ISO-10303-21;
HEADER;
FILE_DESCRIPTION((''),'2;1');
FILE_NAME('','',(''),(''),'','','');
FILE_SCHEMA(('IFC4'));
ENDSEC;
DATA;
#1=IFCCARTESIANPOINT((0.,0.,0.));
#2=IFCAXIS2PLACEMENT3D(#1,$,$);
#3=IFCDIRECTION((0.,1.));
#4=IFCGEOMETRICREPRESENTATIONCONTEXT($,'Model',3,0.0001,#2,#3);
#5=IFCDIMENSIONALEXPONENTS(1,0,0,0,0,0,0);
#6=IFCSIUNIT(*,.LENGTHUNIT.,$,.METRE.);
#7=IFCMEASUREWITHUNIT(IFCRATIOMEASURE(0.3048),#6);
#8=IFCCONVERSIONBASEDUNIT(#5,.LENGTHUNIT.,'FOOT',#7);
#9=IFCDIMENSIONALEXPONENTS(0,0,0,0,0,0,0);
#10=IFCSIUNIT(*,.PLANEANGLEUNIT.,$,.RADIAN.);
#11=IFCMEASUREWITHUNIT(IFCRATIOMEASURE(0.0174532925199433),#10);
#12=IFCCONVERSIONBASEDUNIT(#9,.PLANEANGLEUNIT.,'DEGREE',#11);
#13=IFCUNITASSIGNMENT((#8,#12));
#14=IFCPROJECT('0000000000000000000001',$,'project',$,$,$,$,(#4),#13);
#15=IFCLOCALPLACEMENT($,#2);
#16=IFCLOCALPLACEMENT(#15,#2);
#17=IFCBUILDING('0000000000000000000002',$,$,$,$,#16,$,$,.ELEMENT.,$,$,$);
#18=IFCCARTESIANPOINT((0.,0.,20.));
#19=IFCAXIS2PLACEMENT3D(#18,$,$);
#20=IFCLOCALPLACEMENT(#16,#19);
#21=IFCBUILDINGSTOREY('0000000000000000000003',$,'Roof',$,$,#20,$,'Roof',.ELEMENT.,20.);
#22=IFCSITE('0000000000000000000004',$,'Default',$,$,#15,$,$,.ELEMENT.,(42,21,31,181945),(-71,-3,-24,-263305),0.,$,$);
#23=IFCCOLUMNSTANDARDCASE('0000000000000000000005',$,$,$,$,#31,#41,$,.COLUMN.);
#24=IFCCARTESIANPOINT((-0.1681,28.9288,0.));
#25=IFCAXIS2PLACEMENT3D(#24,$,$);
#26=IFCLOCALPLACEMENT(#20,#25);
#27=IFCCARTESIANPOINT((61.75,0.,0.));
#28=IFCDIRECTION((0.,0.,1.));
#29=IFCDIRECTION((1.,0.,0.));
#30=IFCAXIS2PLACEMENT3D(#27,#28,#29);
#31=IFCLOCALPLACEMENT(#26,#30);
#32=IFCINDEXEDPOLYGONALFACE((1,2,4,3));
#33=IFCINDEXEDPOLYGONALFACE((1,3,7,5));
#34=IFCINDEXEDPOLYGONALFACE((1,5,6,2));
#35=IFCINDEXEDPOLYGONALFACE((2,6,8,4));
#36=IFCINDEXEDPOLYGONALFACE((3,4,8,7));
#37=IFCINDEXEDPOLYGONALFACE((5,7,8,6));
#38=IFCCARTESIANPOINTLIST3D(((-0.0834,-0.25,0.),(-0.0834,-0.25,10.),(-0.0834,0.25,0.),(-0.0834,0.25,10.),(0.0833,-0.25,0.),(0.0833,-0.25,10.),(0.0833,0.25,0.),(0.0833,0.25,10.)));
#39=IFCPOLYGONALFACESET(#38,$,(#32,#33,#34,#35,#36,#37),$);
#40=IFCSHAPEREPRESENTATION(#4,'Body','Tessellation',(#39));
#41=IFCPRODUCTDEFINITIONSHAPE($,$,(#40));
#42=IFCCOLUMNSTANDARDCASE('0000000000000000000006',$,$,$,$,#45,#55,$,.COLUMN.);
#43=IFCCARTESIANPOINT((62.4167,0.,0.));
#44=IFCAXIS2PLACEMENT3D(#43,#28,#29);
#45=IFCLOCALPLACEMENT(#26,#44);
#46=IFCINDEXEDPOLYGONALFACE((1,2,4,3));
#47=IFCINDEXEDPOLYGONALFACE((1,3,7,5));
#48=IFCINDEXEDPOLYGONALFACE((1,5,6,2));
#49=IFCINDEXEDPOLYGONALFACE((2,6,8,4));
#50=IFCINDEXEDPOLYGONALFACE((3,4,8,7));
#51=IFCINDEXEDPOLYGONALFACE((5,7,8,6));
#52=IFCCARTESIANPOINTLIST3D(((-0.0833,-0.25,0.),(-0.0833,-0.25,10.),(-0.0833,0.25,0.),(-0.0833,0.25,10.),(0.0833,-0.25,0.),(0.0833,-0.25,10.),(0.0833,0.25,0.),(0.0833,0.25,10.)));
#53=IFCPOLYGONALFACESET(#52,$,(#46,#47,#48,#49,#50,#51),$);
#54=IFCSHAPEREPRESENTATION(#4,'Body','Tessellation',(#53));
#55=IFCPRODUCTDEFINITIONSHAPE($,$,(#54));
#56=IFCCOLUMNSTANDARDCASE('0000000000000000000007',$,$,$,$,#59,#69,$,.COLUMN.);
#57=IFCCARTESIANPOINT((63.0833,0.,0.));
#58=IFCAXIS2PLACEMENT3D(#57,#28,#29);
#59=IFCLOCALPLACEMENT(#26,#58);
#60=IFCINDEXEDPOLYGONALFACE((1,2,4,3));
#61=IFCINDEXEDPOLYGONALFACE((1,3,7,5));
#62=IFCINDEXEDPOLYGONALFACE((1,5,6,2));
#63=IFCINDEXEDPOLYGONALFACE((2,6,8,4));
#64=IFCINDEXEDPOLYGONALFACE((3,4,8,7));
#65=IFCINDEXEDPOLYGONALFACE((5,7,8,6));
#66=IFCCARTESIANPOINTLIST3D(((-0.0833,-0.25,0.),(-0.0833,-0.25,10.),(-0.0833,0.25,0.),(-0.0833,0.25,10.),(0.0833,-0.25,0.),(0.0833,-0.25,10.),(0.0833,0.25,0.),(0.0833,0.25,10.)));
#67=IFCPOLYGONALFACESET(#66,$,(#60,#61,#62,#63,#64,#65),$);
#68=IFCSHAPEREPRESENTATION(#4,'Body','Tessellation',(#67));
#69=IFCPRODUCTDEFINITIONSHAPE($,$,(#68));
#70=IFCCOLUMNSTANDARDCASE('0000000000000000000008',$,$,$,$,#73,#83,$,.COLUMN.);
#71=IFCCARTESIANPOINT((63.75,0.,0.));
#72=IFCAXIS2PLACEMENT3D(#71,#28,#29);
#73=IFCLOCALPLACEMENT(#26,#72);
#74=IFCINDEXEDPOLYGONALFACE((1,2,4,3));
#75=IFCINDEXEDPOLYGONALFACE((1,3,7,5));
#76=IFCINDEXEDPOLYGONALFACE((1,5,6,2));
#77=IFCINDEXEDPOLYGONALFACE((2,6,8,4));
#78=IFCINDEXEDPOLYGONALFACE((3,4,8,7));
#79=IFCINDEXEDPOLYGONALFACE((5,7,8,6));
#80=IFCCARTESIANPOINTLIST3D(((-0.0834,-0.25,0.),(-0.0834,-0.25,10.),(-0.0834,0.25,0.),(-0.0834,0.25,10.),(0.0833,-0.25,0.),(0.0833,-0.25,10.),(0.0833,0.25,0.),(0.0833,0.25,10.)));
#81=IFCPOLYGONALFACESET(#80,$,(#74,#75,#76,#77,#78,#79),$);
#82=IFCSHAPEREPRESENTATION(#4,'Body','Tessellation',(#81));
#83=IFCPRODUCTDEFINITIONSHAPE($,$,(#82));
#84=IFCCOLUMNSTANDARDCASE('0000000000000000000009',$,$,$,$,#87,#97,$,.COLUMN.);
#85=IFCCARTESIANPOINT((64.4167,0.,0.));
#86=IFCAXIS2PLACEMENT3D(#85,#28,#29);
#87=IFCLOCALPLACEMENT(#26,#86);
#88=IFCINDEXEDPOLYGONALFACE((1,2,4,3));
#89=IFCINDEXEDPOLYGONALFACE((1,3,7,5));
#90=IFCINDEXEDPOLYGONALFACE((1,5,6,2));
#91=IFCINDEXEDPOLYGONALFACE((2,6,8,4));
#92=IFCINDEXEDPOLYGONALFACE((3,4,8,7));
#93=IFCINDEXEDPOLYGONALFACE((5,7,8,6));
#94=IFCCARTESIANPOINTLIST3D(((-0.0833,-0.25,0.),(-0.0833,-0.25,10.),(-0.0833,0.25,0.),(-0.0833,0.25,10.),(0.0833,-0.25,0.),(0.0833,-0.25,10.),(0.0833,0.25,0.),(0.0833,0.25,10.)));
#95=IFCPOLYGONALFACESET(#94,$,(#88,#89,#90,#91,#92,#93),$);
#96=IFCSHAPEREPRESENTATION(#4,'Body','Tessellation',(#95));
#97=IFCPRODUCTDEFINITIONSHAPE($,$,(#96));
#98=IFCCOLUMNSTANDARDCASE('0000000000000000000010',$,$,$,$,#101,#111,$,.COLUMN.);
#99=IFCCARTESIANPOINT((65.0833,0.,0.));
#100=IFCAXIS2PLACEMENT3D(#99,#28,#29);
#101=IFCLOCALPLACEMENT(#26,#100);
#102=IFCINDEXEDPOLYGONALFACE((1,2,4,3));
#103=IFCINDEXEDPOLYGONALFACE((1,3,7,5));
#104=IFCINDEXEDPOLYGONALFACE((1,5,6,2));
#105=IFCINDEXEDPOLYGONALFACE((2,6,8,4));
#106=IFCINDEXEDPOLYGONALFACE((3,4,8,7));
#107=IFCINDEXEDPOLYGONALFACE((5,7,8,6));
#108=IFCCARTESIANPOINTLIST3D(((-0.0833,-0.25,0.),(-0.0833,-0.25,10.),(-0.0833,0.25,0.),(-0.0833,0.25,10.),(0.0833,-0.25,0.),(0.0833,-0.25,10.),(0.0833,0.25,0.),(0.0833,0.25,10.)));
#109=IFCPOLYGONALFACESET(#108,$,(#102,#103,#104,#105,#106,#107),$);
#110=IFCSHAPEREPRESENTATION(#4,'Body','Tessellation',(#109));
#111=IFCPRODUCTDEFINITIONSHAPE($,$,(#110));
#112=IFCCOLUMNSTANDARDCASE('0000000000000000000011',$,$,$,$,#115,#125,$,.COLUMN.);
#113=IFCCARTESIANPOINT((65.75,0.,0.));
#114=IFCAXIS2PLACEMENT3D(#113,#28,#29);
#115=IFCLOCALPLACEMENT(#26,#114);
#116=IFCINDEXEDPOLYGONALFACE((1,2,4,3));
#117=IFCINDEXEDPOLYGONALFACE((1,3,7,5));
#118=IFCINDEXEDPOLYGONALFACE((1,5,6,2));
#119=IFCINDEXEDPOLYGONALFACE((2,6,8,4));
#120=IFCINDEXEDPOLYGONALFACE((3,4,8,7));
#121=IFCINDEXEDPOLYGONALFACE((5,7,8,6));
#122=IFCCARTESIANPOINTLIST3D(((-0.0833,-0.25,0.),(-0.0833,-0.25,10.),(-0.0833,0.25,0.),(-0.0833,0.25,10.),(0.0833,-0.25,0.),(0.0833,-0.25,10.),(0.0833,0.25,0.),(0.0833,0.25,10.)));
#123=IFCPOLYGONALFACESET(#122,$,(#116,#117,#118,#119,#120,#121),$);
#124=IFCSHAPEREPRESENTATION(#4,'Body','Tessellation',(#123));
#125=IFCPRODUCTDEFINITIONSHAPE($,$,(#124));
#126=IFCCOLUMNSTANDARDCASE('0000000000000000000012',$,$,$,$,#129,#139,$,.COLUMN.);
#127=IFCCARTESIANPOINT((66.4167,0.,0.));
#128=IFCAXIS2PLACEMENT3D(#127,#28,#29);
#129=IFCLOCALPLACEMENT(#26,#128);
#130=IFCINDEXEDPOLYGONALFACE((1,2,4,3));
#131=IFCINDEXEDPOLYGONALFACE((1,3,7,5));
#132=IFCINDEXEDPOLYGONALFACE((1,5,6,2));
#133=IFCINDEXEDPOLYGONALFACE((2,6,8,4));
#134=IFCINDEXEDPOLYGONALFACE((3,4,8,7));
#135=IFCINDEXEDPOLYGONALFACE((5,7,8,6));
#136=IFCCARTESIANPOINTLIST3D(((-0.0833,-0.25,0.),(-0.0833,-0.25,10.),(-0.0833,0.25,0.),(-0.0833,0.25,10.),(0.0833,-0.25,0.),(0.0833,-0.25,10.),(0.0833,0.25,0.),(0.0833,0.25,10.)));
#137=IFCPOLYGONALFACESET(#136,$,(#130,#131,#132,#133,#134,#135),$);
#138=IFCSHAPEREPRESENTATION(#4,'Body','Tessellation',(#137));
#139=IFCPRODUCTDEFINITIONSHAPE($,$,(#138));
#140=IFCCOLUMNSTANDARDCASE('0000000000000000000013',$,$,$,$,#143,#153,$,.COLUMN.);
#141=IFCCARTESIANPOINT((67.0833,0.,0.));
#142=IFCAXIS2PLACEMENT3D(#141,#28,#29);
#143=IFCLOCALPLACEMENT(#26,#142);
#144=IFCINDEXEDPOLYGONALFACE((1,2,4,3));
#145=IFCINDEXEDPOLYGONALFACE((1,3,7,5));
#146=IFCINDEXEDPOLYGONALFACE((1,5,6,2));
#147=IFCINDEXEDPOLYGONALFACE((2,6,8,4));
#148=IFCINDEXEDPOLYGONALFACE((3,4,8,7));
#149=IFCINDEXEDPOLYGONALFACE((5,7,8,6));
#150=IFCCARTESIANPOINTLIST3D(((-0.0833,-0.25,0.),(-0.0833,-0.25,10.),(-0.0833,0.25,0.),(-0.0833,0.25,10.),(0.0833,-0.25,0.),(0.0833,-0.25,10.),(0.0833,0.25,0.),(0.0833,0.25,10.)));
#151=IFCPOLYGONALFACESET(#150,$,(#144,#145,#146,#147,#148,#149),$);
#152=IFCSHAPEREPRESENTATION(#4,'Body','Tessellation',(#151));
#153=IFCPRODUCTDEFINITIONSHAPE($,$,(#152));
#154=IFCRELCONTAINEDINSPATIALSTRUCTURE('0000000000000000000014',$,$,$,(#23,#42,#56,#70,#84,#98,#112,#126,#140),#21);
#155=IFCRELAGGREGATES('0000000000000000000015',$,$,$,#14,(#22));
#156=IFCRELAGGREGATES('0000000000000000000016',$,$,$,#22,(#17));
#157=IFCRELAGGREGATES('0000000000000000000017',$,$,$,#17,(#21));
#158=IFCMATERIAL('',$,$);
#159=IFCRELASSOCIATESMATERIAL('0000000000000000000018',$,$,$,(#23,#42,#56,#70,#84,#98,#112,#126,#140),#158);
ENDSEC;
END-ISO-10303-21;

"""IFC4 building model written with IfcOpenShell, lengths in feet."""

from ifc_helpers import new_model, entity, si_unit, converted_unit, direction, frame, origin, place, context, project, spatial, rectangle, extrude, material, element, save


model = new_model("IFC4")

# Units and contexts
model_context = context("Model", 3, precision=0.0001, world=origin(), true_north=direction((0.0, 1.0)))
ifc_project = project(units=[converted_unit("LENGTHUNIT", "FOOT", entity("IfcRatioMeasure", 0.3048), si_unit("LENGTHUNIT", "METRE"), dimensions=[1, 0, 0, 0, 0, 0, 0]), converted_unit("PLANEANGLEUNIT", "DEGREE", entity("IfcRatioMeasure", 0.0174532925199433), si_unit("PLANEANGLEUNIT", "RADIAN"), dimensions=[0, 0, 0, 0, 0, 0, 0])], contexts=[model_context])

# Site, building, storey
site_placement = place(None, origin())
site = spatial("IfcSite", under=ifc_project, at=site_placement, Name="Default", CompositionType="ELEMENT", RefLatitude=(42, 21, 31, 181945), RefLongitude=(-71, -3, -24, -263305), RefElevation=0.0)
building_placement = place(site_placement, origin())
building = spatial("IfcBuilding", under=site, at=building_placement, CompositionType="ELEMENT")
storey_placement = place(building_placement, frame((0.0, 0.0, 20.0)))
storey = spatial("IfcBuildingStorey", under=building, at=storey_placement, Name="Roof", LongName="Roof", CompositionType="ELEMENT", Elevation=20.0)

# Columns
ifc_material_1 = material(Name="")
placement = place(storey_placement, frame((-0.1681, 28.9288, 0.0)))
for number, where, z_axis, x_axis in (
    (1, (61.75, 0.0, 0.0), (0.0, 0.0, 1.0), (1.0, 0.0, 0.0)),
    (2, (62.4167, 0.0, 0.0), (0.0, 0.0, 1.0), (1.0, 0.0, 0.0)),
    (3, (63.0833, 0.0, 0.0), (0.0, 0.0, 1.0), (1.0, 0.0, 0.0)),
    (4, (63.75, 0.0, 0.0), (0.0, 0.0, 1.0), (1.0, 0.0, 0.0)),
    (5, (64.4167, 0.0, 0.0), (0.0, 0.0, 1.0), (1.0, 0.0, 0.0)),
    (6, (65.0833, 0.0, 0.0), (0.0, 0.0, 1.0), (1.0, 0.0, 0.0)),
    (7, (65.75, 0.0, 0.0), (0.0, 0.0, 1.0), (1.0, 0.0, 0.0)),
    (8, (66.4167, 0.0, 0.0), (0.0, 0.0, 1.0), (1.0, 0.0, 0.0)),
    (9, (67.0833, 0.0, 0.0), (0.0, 0.0, 1.0), (1.0, 0.0, 0.0)),
):
    element("IfcColumnStandardCase", number, at=place(placement, frame(where, z_axis=z_axis, x_axis=x_axis)), inside=storey, material=ifc_material_1, PredefinedType="COLUMN", context=model_context, shape_type="SweptSolid", body=[
        extrude(rectangle(XDim=0.1667, YDim=0.5), origin(), (0.0, 0.0, 1.0), 10.0),
    ])

save(model, "model.ifc")
